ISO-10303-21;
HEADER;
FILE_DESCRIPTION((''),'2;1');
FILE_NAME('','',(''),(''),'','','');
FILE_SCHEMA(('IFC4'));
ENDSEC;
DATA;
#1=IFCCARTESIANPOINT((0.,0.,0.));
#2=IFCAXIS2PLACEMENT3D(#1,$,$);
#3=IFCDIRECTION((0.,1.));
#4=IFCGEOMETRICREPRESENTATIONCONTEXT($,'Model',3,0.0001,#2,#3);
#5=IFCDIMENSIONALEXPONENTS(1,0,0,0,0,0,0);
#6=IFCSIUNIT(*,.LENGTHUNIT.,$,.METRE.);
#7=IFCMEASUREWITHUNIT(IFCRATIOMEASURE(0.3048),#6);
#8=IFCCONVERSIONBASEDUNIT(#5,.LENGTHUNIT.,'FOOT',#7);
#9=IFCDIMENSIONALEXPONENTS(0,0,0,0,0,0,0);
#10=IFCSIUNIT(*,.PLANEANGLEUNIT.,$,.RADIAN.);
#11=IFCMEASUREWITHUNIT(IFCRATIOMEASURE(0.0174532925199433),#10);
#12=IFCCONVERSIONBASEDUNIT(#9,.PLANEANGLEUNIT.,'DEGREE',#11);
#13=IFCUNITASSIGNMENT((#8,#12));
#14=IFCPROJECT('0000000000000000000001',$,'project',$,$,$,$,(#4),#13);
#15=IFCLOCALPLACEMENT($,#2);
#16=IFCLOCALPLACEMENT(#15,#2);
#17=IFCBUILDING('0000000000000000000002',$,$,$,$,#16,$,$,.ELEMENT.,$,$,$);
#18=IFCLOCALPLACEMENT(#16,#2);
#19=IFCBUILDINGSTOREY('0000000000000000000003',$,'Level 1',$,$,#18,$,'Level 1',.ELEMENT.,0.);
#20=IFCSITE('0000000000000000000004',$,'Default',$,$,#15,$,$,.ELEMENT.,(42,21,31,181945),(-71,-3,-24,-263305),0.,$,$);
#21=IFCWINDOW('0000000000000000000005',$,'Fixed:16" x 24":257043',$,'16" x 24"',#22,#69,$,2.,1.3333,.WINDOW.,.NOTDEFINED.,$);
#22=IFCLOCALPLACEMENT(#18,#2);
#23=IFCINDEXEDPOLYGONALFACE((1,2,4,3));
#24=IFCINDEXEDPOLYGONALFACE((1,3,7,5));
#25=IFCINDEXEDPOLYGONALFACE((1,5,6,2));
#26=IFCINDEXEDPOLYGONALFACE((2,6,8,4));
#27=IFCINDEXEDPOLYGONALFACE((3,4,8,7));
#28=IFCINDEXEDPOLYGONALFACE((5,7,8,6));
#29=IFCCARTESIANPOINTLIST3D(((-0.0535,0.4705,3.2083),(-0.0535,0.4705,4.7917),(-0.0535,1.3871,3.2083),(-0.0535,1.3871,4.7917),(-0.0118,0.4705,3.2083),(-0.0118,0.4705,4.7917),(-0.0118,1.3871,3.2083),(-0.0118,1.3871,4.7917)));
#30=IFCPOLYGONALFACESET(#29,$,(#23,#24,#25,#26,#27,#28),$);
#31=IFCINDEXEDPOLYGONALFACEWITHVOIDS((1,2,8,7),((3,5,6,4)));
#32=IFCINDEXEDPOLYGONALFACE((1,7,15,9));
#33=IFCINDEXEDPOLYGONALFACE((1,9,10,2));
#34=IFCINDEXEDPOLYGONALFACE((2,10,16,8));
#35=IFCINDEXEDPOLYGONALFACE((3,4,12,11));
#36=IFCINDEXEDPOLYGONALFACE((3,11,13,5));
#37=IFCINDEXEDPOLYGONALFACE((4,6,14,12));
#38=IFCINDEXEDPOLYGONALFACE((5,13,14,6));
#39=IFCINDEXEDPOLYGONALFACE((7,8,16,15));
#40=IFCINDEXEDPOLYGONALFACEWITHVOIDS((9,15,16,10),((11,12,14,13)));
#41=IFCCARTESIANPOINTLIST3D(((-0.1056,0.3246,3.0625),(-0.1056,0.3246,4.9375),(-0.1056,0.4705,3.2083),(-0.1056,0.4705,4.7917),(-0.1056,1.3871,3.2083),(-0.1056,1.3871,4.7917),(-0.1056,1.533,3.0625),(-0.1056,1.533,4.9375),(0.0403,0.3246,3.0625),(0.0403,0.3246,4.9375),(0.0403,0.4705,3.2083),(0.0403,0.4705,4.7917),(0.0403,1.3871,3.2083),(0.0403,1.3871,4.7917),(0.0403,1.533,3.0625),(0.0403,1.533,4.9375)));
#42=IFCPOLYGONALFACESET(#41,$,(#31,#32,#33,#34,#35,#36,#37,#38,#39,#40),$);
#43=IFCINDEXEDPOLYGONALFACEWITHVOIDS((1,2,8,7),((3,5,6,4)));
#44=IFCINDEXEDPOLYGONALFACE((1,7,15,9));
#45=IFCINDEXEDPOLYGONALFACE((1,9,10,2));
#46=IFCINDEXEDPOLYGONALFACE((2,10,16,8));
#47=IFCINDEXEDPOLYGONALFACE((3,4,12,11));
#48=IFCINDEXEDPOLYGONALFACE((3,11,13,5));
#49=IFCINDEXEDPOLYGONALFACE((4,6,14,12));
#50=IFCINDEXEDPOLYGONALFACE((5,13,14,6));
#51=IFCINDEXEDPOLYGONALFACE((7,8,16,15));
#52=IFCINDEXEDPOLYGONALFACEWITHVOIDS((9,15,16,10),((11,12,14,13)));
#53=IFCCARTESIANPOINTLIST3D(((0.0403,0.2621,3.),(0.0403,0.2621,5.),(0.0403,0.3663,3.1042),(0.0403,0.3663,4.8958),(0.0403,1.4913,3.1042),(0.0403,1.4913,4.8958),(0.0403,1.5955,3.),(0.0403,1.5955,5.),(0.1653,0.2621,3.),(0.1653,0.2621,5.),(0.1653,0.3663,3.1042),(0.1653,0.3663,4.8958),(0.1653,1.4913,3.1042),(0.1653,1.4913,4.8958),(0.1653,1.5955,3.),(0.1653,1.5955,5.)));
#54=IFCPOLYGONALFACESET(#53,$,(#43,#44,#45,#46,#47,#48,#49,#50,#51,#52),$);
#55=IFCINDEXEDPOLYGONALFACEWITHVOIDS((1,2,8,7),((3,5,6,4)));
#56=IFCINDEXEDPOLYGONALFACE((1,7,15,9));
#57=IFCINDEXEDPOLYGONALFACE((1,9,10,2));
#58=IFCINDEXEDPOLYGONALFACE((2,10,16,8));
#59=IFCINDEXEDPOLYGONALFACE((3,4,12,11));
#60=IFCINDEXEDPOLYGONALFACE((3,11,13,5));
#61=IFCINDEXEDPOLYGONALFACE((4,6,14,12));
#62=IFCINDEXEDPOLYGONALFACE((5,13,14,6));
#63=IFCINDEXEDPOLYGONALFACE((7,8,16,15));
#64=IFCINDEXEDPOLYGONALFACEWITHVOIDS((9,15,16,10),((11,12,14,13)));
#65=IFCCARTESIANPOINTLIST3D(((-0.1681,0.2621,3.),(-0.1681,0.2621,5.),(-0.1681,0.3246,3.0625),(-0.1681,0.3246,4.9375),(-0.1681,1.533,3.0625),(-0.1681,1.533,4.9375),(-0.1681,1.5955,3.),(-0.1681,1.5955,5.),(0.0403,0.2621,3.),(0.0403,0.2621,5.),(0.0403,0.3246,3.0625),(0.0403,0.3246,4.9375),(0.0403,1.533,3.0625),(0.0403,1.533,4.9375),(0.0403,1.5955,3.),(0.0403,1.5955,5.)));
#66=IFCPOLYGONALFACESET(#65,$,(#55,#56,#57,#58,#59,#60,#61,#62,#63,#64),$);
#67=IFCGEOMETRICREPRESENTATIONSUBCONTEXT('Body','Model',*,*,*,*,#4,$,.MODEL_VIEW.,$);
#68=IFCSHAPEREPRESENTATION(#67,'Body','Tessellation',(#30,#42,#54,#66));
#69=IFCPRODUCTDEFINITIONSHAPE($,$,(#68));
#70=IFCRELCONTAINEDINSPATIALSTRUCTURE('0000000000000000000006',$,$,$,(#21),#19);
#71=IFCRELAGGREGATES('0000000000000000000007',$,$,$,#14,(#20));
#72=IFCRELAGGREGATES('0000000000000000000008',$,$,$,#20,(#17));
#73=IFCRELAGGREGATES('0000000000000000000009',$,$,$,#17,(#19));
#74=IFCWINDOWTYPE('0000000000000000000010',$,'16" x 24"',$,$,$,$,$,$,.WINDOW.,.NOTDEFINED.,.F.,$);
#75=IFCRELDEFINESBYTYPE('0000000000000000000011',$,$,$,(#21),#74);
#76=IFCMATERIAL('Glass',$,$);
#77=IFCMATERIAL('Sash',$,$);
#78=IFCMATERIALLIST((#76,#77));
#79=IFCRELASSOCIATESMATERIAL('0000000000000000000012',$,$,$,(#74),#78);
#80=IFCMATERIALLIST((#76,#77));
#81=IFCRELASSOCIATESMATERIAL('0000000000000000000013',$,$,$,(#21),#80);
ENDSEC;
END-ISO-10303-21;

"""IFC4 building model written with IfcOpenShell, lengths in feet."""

from ifc_helpers import new_model, entity, si_unit, converted_unit, direction, frame, origin, origin_2d_with_axis, place, context, subcontext, project, spatial, polyline, rectangle, outline, extrude, source, transform, mapped, material, material_list, type_object, type_shapes, element, save


model = new_model("IFC4")

# Units and contexts
model_context = context("Model", 3, precision=0.0001, world=origin(), true_north=direction((0.0, 1.0)))
body_context = subcontext(model_context, "Body", "Model", "MODEL_VIEW")
ifc_project = project(units=[converted_unit("LENGTHUNIT", "FOOT", entity("IfcRatioMeasure", 0.3048), si_unit("LENGTHUNIT", "METRE"), dimensions=[1, 0, 0, 0, 0, 0, 0]), converted_unit("PLANEANGLEUNIT", "DEGREE", entity("IfcRatioMeasure", 0.0174532925199433), si_unit("PLANEANGLEUNIT", "RADIAN"), dimensions=[0, 0, 0, 0, 0, 0, 0])], contexts=[model_context])

# Site, building, storey
site_placement = place(None, origin())
site = spatial("IfcSite", under=ifc_project, at=site_placement, Name="Default", CompositionType="ELEMENT", RefLatitude=(42, 21, 31, 181945), RefLongitude=(-71, -3, -24, -263305), RefElevation=0.0)
building_placement = place(site_placement, origin())
building = spatial("IfcBuilding", under=site, at=building_placement, CompositionType="ELEMENT")
storey_placement = place(building_placement, origin())
storey = spatial("IfcBuildingStorey", under=building, at=storey_placement, Name="Level 1", LongName="Level 1", CompositionType="ELEMENT", Elevation=0.0)

# Shared definitions
placement_1 = place(storey_placement, frame((-0.0014, -6.9045, 0.0), z_axis=(0.0, 0.0, 1.0), x_axis=(0.0, 1.0, 0.0)))

# Window
ifc_material_1 = material(Name="Glass")
ifc_material_2 = material(Name="Sash")
ifc_material_list_1 = material_list([ifc_material_1, ifc_material_2])
ifc_material_list_2 = material_list([ifc_material_1, ifc_material_2])
window_type = type_object("IfcWindowType", Name="16\" x 24\"", ParameterTakesPrecedence=False, PartitioningType="NOTDEFINED", PredefinedType="WINDOW", material=ifc_material_list_2)
shared_shape = source(origin(), body_context, "Body", "SweptSolid", [
    extrude(rectangle(XDim=0.0417, YDim=0.9167, at=origin_2d_with_axis()), frame((0.6667, 0.1979, 0.2083), z_axis=(0.0, 0.0, 1.0), x_axis=(0.0, 1.0, 0.0)), (0.0, 0.0, 1.0), 1.5833),
    extrude(outline(polyline([(-0.6042, -0.9375), (0.6042, -0.9375), (0.6042, 0.9375), (-0.6042, 0.9375), (-0.6042, -0.9375)]), holes=[polyline([(-0.4583, -0.7917), (-0.4583, 0.7917), (0.4583, 0.7917), (0.4583, -0.7917), (-0.4583, -0.7917)])]), frame((0.6667, 0.125, 1.0), z_axis=(0.0, 1.0, 0.0), x_axis=(1.0, 0.0, 0.0)), (0.0, 0.0, 1.0), 0.1458),
    extrude(outline(polyline([(-0.6667, -1.0), (0.6667, -1.0), (0.6667, 1.0), (-0.6667, 1.0), (-0.6667, -1.0)]), holes=[polyline([(-0.5625, -0.8958), (-0.5625, 0.8958), (0.5625, 0.8958), (0.5625, -0.8958), (-0.5625, -0.8958)])]), frame((0.6667, 0.0, 1.0), z_axis=(0.0, 1.0, 0.0), x_axis=(1.0, 0.0, 0.0)), (0.0, 0.0, 1.0), 0.125),
    extrude(outline(polyline([(-1.0, -0.6667), (1.0, -0.6667), (1.0, 0.6667), (-1.0, 0.6667), (-1.0, -0.6667)]), holes=[polyline([(-0.9375, -0.6042), (-0.9375, 0.6042), (0.9375, 0.6042), (0.9375, -0.6042), (-0.9375, -0.6042)])]), frame((0.6667, 0.125, 1.0), z_axis=(0.0, 1.0, 0.0), x_axis=(0.0, 0.0, -1.0)), (0.0, 0.0, 1.0), 0.2083),
])
type_shapes(window_type, [shared_shape])
placement_2 = place(placement_1, frame((7.1667, -0.1667, 3.0)))
window_placement = place(placement_2, origin())
element("IfcWindow", 1, at=window_placement, inside=storey, type_object=window_type, material=ifc_material_list_1, Name="Fixed:16\" x 24\":257043", ObjectType="16\" x 24\"", OverallHeight=2.0, OverallWidth=1.3333, PartitioningType="NOTDEFINED", PredefinedType="WINDOW", context=body_context, shape_type="MappedRepresentation", body=[
    mapped(shared_shape, transform((0.0, 0.0, 0.0), scale=1.0)),
])

save(model, "model.ifc")
